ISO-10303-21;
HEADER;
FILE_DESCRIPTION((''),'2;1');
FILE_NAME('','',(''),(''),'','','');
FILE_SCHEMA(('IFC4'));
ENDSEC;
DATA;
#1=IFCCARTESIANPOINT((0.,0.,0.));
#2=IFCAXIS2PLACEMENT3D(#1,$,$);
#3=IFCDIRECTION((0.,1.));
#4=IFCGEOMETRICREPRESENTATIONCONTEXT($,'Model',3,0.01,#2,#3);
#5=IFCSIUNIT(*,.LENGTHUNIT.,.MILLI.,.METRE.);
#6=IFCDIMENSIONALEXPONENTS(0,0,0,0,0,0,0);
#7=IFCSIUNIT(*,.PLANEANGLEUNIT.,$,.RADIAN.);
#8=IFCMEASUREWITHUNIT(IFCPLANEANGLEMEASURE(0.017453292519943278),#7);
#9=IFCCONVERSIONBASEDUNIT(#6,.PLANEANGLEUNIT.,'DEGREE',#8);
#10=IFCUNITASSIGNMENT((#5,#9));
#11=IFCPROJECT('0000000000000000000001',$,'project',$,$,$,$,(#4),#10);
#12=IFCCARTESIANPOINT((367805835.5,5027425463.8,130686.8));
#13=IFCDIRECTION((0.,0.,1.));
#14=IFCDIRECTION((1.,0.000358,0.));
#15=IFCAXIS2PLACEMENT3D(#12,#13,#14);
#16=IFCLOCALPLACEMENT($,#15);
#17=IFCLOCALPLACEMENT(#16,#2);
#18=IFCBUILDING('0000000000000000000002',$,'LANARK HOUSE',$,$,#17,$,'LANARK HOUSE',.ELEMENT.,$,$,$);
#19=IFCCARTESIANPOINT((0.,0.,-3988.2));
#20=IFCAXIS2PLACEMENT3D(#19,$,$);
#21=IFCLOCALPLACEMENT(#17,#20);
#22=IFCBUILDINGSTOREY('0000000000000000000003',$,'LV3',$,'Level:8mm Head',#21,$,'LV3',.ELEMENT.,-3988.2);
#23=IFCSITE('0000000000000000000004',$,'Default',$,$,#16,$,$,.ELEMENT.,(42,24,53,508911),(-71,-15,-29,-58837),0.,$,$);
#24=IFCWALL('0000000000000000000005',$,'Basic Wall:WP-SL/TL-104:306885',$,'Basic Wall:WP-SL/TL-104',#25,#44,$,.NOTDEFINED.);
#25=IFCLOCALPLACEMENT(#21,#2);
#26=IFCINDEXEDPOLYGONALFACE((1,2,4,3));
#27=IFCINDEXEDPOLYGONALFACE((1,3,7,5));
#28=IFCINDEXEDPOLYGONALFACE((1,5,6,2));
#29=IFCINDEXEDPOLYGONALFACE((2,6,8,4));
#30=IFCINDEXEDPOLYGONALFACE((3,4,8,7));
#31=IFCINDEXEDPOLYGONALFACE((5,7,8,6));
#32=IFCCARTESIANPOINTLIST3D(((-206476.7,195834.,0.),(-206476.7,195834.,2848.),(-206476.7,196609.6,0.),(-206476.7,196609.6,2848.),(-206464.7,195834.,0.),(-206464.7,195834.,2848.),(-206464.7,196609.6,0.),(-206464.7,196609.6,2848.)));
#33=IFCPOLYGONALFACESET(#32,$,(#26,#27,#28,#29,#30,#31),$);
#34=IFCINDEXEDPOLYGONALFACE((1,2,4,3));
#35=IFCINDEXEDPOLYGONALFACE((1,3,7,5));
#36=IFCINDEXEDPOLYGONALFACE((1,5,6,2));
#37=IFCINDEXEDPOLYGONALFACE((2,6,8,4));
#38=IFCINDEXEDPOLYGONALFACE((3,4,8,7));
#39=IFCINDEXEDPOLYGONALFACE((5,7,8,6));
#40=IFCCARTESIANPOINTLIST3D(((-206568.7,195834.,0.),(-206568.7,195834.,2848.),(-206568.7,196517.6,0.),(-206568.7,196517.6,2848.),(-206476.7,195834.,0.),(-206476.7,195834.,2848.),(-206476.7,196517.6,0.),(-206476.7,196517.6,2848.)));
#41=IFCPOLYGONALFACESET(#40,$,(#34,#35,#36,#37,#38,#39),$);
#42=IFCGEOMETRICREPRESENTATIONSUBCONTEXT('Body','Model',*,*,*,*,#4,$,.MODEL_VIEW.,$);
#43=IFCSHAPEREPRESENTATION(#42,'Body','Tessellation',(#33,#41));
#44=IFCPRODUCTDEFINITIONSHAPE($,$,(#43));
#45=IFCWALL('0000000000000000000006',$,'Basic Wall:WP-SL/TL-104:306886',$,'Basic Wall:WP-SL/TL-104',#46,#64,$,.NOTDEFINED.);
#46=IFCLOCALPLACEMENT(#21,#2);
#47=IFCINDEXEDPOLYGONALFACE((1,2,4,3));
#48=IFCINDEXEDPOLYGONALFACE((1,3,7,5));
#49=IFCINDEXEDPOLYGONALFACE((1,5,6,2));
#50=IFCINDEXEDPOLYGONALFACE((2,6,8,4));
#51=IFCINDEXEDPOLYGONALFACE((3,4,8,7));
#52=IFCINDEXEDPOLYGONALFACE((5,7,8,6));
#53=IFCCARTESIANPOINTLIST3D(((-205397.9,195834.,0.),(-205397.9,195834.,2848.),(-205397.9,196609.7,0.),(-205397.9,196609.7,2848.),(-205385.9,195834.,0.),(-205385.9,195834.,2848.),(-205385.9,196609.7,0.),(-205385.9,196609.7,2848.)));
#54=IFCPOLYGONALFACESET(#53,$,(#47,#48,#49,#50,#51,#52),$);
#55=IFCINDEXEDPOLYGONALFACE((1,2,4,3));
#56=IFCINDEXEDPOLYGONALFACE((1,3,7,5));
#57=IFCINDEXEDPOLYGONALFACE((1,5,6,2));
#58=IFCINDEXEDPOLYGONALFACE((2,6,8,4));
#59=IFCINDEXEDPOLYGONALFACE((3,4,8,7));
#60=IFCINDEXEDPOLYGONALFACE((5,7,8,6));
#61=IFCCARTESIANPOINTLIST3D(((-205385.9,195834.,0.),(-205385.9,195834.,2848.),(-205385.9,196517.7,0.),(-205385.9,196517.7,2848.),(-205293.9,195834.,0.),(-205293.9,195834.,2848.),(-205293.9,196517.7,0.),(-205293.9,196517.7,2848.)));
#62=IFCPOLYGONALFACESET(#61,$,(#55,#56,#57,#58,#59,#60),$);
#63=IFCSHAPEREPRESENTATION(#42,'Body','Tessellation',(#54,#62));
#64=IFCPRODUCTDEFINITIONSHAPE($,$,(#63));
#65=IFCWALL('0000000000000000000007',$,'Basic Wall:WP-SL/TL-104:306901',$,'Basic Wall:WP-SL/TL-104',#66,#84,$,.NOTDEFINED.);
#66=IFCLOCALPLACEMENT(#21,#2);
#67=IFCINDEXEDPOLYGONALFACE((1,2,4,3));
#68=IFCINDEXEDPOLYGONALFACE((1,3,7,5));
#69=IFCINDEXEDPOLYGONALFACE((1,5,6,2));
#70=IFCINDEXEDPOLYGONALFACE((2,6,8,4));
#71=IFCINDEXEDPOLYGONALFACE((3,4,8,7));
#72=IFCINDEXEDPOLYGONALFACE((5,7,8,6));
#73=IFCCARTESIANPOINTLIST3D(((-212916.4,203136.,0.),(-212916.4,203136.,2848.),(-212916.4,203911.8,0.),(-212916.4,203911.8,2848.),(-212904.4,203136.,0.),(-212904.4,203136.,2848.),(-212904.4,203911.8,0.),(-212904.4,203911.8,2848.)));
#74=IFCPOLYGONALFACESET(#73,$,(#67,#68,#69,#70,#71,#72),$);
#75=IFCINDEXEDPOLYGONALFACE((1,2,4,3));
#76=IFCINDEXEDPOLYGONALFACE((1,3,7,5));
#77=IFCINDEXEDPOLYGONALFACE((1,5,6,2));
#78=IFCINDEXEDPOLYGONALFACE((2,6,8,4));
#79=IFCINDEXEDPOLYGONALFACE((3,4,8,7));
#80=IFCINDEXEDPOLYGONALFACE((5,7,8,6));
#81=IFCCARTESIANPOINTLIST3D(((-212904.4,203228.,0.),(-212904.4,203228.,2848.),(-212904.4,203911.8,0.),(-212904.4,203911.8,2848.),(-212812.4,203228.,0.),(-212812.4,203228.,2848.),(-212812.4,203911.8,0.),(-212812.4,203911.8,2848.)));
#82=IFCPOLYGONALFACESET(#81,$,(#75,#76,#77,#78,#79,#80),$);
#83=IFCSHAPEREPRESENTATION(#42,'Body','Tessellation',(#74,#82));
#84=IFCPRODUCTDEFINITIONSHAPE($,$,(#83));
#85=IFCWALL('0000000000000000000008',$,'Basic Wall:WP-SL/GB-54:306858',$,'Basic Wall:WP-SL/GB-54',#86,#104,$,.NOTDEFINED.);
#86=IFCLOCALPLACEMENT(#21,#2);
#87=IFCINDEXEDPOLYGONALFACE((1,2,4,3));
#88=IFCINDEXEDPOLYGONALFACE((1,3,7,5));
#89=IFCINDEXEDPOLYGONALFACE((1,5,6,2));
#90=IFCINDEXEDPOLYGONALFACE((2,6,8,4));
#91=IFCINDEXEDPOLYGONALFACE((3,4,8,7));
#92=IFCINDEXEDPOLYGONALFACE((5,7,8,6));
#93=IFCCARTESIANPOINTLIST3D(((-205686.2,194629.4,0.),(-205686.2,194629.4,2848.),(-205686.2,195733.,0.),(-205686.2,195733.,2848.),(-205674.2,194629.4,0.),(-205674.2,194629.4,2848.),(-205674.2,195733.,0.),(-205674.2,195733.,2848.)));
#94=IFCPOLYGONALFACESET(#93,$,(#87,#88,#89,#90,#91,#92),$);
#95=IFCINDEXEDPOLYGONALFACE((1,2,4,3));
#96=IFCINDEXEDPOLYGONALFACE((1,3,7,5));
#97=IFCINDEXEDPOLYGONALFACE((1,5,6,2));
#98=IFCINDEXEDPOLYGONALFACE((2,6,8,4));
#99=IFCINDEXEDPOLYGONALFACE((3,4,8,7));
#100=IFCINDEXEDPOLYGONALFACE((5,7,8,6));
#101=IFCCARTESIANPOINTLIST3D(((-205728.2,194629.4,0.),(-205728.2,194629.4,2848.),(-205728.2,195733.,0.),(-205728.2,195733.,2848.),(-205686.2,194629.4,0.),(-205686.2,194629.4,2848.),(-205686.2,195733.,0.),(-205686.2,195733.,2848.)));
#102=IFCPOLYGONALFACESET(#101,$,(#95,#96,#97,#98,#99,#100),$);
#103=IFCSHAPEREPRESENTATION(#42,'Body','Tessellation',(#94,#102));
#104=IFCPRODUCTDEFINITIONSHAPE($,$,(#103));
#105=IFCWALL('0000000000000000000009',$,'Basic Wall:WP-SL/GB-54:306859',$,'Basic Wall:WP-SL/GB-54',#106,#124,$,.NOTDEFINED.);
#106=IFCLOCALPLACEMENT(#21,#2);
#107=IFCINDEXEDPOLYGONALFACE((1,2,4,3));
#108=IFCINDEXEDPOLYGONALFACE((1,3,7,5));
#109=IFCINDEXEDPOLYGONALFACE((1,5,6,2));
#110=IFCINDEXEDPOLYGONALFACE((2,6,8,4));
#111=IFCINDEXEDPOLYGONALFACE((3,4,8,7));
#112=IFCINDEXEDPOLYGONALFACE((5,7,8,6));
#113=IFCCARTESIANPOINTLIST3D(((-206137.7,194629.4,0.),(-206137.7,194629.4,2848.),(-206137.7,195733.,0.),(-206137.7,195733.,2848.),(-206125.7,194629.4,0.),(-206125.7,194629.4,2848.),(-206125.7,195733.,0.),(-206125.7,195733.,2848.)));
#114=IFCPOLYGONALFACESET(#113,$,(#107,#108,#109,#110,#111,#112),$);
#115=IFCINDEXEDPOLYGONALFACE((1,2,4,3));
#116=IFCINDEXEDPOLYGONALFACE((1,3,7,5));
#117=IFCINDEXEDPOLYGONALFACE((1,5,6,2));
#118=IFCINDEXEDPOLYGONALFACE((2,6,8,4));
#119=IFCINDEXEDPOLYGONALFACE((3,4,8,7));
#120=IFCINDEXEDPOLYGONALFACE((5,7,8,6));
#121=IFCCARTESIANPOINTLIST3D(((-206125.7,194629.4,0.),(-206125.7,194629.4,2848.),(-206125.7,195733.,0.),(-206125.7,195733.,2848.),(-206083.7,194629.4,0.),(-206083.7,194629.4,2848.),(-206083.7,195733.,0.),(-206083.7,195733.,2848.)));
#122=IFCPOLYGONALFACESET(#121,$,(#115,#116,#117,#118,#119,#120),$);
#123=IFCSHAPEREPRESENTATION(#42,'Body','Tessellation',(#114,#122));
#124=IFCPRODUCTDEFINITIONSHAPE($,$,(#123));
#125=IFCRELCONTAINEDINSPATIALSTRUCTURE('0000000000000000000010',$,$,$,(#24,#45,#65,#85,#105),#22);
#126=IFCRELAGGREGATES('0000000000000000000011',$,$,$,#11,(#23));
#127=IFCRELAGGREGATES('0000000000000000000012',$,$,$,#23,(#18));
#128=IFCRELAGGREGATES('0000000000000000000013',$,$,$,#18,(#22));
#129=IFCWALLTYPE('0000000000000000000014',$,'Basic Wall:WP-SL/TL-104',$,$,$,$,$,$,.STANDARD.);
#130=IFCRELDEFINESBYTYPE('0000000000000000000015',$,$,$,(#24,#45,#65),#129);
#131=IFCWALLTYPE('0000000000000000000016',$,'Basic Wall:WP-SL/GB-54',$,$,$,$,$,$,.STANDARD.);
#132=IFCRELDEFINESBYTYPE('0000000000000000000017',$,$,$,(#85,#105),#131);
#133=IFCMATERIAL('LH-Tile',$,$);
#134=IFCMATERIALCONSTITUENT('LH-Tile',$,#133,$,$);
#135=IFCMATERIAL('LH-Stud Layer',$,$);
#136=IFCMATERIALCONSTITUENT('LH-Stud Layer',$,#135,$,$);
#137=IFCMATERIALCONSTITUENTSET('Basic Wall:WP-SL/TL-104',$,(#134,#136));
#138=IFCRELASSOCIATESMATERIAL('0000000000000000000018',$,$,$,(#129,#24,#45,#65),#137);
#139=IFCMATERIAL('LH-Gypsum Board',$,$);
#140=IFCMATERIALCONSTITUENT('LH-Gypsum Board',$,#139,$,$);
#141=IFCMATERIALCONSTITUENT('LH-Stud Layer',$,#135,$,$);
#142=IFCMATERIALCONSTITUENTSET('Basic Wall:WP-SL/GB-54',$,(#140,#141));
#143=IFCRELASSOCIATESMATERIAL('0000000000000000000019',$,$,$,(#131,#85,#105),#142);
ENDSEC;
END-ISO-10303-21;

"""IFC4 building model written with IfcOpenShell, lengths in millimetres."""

from ifc_helpers import new_model, entity, si_unit, converted_unit, direction, frame, origin, place, context, subcontext, project, spatial, indexed_curve, outline, extrude, material, constituent, constituent_set, type_object, element, save


model = new_model("IFC4")

# Units and contexts
model_context = context("Model", 3, precision=0.01, world=origin(), true_north=direction((0.0, 1.0)))
body_context = subcontext(model_context, "Body", "Model", "MODEL_VIEW")
ifc_project = project(units=[si_unit("LENGTHUNIT", "METRE", prefix="MILLI"), converted_unit("PLANEANGLEUNIT", "DEGREE", entity("IfcPlaneAngleMeasure", 0.017453292519943278), si_unit("PLANEANGLEUNIT", "RADIAN"), dimensions=[0, 0, 0, 0, 0, 0, 0])], contexts=[model_context])

# Site, building, storey
site_placement = place(None, frame((367805835.5, 5027425463.8, 130686.8), z_axis=(0.0, 0.0, 1.0), x_axis=(1.0, 0.000358, 0.0)))
site = spatial("IfcSite", under=ifc_project, at=site_placement, Name="Default", CompositionType="ELEMENT", RefLatitude=(42, 24, 53, 508911), RefLongitude=(-71, -15, -29, -58837), RefElevation=0.0)
building_placement = place(site_placement, origin())
building = spatial("IfcBuilding", under=site, at=building_placement, Name="LANARK HOUSE", LongName="LANARK HOUSE", CompositionType="ELEMENT")
storey_placement = place(building_placement, frame((0.0, 0.0, -3988.2)))
storey = spatial("IfcBuildingStorey", under=building, at=storey_placement, Name="LV3", ObjectType="Level:8mm Head", LongName="LV3", CompositionType="ELEMENT", Elevation=-3988.2)

# Walls
ifc_material_1 = material(Name="LH-Tile")
ifc_constituent_1 = constituent(ifc_material_1, Name="LH-Tile")
ifc_material_2 = material(Name="LH-Stud Layer")
ifc_constituent_2 = constituent(ifc_material_2, Name="LH-Stud Layer")
ifc_constituent_set_1 = constituent_set(constituents=[ifc_constituent_1, ifc_constituent_2], Name="Basic Wall:WP-SL/TL-104")
wall_type_1 = type_object("IfcWallType", Name="Basic Wall:WP-SL/TL-104", PredefinedType="STANDARD", material=ifc_constituent_set_1)
wall_1_placement = place(storey_placement, frame((-206516.7, 196517.6, 0.0), z_axis=(0.0, 0.0, 1.0), x_axis=(0.0, -1.0, 0.0)))
element("IfcWall", 1, at=wall_1_placement, inside=storey, type_object=wall_type_1, material=ifc_constituent_set_1, Name="Basic Wall:WP-SL/TL-104:306885", ObjectType="Basic Wall:WP-SL/TL-104", PredefinedType="NOTDEFINED", context=body_context, shape_type="SweptSolid", body=[
    extrude(outline(indexed_curve([(-6.0, -387.8), (6.0, -387.8), (6.0, 387.8), (-6.0, 387.8), (-6.0, -387.8)], self_intersect=False)), frame((295.8, 46.0, 0.0), z_axis=(0.0, 0.0, 1.0), x_axis=(0.0, -1.0, 0.0)), (0.0, 0.0, 1.0), 2848.0),
    extrude(outline(indexed_curve([(-46.0, -341.8), (46.0, -341.8), (46.0, 341.8), (-46.0, 341.8), (-46.0, -341.8)], self_intersect=False)), frame((341.8, -6.0, 0.0), z_axis=(0.0, 0.0, 1.0), x_axis=(0.0, 1.0, 0.0)), (0.0, 0.0, 1.0), 2848.0),
])
wall_2_placement = place(storey_placement, frame((-205345.9, 195834.0, 0.0), z_axis=(0.0, 0.0, 1.0), x_axis=(0.0, 1.0, 0.0)))
element("IfcWall", 2, at=wall_2_placement, inside=storey, type_object=wall_type_1, material=ifc_constituent_set_1, Name="Basic Wall:WP-SL/TL-104:306886", ObjectType="Basic Wall:WP-SL/TL-104", PredefinedType="NOTDEFINED", context=body_context, shape_type="SweptSolid", body=[
    extrude(outline(indexed_curve([(-6.0, -387.8), (6.0, -387.8), (6.0, 387.8), (-6.0, 387.8), (-6.0, -387.8)], self_intersect=False)), frame((387.8, 46.0, 0.0), z_axis=(0.0, 0.0, 1.0), x_axis=(0.0, -1.0, 0.0)), (0.0, 0.0, 1.0), 2848.0),
    extrude(outline(indexed_curve([(-46.0, -341.8), (46.0, -341.8), (46.0, 341.8), (-46.0, 341.8), (-46.0, -341.8)], self_intersect=False)), frame((341.8, -6.0, 0.0), z_axis=(0.0, 0.0, 1.0), x_axis=(0.0, 1.0, 0.0)), (0.0, 0.0, 1.0), 2848.0),
])
wall_3_placement = place(storey_placement, frame((-212864.4, 203228.0, 0.0), z_axis=(0.0, 0.0, 1.0), x_axis=(0.0, 1.0, 0.0)))
element("IfcWall", 3, at=wall_3_placement, inside=storey, type_object=wall_type_1, material=ifc_constituent_set_1, Name="Basic Wall:WP-SL/TL-104:306901", ObjectType="Basic Wall:WP-SL/TL-104", PredefinedType="NOTDEFINED", context=body_context, shape_type="SweptSolid", body=[
    extrude(outline(indexed_curve([(-6.0, -387.9), (6.0, -387.9), (6.0, 387.9), (-6.0, 387.9), (-6.0, -387.9)], self_intersect=False)), frame((295.9, 46.0, 0.0), z_axis=(0.0, 0.0, 1.0), x_axis=(0.0, -1.0, 0.0)), (0.0, 0.0, 1.0), 2848.0),
    extrude(outline(indexed_curve([(-46.0, -341.9), (46.0, -341.9), (46.0, 341.9), (-46.0, 341.9), (-46.0, -341.9)], self_intersect=False)), frame((341.9, -6.0, 0.0), z_axis=(0.0, 0.0, 1.0), x_axis=(0.0, 1.0, 0.0)), (0.0, 0.0, 1.0), 2848.0),
])
ifc_material_3 = material(Name="LH-Gypsum Board")
ifc_constituent_3 = constituent(ifc_material_3, Name="LH-Gypsum Board")
ifc_constituent_4 = constituent(ifc_material_2, Name="LH-Stud Layer")
ifc_constituent_set_2 = constituent_set(constituents=[ifc_constituent_3, ifc_constituent_4], Name="Basic Wall:WP-SL/GB-54")
wall_type_2 = type_object("IfcWallType", Name="Basic Wall:WP-SL/GB-54", PredefinedType="STANDARD", material=ifc_constituent_set_2)
wall_4_placement = place(storey_placement, frame((-205701.2, 195733.0, 0.0), z_axis=(0.0, 0.0, 1.0), x_axis=(0.0, -1.0, 0.0)))
element("IfcWall", 4, at=wall_4_placement, inside=storey, type_object=wall_type_2, material=ifc_constituent_set_2, Name="Basic Wall:WP-SL/GB-54:306858", ObjectType="Basic Wall:WP-SL/GB-54", PredefinedType="NOTDEFINED", context=body_context, shape_type="SweptSolid", body=[
    extrude(outline(indexed_curve([(-6.0, -551.8), (6.0, -551.8), (6.0, 551.8), (-6.0, 551.8), (-6.0, -551.8)], self_intersect=False)), frame((551.8, 21.0, 0.0), z_axis=(0.0, 0.0, 1.0), x_axis=(0.0, -1.0, 0.0)), (0.0, 0.0, 1.0), 2848.0),
    extrude(outline(indexed_curve([(-21.0, -551.8), (21.0, -551.8), (21.0, 551.8), (-21.0, 551.8), (-21.0, -551.8)], self_intersect=False)), frame((551.8, -6.0, 0.0), z_axis=(0.0, 0.0, 1.0), x_axis=(0.0, 1.0, 0.0)), (0.0, 0.0, 1.0), 2848.0),
])
wall_5_placement = place(storey_placement, frame((-206110.7, 194629.4, 0.0), z_axis=(0.0, 0.0, 1.0), x_axis=(0.0, 1.0, 0.0)))
element("IfcWall", 5, at=wall_5_placement, inside=storey, type_object=wall_type_2, material=ifc_constituent_set_2, Name="Basic Wall:WP-SL/GB-54:306859", ObjectType="Basic Wall:WP-SL/GB-54", PredefinedType="NOTDEFINED", context=body_context, shape_type="SweptSolid", body=[
    extrude(outline(indexed_curve([(-6.0, -551.8), (6.0, -551.8), (6.0, 551.8), (-6.0, 551.8), (-6.0, -551.8)], self_intersect=False)), frame((551.8, 21.0, 0.0), z_axis=(0.0, 0.0, 1.0), x_axis=(0.0, -1.0, 0.0)), (0.0, 0.0, 1.0), 2848.0),
    extrude(outline(indexed_curve([(-21.0, -551.8), (21.0, -551.8), (21.0, 551.8), (-21.0, 551.8), (-21.0, -551.8)], self_intersect=False)), frame((551.8, -6.0, 0.0), z_axis=(0.0, 0.0, 1.0), x_axis=(0.0, 1.0, 0.0)), (0.0, 0.0, 1.0), 2848.0),
])

save(model, "model.ifc")
